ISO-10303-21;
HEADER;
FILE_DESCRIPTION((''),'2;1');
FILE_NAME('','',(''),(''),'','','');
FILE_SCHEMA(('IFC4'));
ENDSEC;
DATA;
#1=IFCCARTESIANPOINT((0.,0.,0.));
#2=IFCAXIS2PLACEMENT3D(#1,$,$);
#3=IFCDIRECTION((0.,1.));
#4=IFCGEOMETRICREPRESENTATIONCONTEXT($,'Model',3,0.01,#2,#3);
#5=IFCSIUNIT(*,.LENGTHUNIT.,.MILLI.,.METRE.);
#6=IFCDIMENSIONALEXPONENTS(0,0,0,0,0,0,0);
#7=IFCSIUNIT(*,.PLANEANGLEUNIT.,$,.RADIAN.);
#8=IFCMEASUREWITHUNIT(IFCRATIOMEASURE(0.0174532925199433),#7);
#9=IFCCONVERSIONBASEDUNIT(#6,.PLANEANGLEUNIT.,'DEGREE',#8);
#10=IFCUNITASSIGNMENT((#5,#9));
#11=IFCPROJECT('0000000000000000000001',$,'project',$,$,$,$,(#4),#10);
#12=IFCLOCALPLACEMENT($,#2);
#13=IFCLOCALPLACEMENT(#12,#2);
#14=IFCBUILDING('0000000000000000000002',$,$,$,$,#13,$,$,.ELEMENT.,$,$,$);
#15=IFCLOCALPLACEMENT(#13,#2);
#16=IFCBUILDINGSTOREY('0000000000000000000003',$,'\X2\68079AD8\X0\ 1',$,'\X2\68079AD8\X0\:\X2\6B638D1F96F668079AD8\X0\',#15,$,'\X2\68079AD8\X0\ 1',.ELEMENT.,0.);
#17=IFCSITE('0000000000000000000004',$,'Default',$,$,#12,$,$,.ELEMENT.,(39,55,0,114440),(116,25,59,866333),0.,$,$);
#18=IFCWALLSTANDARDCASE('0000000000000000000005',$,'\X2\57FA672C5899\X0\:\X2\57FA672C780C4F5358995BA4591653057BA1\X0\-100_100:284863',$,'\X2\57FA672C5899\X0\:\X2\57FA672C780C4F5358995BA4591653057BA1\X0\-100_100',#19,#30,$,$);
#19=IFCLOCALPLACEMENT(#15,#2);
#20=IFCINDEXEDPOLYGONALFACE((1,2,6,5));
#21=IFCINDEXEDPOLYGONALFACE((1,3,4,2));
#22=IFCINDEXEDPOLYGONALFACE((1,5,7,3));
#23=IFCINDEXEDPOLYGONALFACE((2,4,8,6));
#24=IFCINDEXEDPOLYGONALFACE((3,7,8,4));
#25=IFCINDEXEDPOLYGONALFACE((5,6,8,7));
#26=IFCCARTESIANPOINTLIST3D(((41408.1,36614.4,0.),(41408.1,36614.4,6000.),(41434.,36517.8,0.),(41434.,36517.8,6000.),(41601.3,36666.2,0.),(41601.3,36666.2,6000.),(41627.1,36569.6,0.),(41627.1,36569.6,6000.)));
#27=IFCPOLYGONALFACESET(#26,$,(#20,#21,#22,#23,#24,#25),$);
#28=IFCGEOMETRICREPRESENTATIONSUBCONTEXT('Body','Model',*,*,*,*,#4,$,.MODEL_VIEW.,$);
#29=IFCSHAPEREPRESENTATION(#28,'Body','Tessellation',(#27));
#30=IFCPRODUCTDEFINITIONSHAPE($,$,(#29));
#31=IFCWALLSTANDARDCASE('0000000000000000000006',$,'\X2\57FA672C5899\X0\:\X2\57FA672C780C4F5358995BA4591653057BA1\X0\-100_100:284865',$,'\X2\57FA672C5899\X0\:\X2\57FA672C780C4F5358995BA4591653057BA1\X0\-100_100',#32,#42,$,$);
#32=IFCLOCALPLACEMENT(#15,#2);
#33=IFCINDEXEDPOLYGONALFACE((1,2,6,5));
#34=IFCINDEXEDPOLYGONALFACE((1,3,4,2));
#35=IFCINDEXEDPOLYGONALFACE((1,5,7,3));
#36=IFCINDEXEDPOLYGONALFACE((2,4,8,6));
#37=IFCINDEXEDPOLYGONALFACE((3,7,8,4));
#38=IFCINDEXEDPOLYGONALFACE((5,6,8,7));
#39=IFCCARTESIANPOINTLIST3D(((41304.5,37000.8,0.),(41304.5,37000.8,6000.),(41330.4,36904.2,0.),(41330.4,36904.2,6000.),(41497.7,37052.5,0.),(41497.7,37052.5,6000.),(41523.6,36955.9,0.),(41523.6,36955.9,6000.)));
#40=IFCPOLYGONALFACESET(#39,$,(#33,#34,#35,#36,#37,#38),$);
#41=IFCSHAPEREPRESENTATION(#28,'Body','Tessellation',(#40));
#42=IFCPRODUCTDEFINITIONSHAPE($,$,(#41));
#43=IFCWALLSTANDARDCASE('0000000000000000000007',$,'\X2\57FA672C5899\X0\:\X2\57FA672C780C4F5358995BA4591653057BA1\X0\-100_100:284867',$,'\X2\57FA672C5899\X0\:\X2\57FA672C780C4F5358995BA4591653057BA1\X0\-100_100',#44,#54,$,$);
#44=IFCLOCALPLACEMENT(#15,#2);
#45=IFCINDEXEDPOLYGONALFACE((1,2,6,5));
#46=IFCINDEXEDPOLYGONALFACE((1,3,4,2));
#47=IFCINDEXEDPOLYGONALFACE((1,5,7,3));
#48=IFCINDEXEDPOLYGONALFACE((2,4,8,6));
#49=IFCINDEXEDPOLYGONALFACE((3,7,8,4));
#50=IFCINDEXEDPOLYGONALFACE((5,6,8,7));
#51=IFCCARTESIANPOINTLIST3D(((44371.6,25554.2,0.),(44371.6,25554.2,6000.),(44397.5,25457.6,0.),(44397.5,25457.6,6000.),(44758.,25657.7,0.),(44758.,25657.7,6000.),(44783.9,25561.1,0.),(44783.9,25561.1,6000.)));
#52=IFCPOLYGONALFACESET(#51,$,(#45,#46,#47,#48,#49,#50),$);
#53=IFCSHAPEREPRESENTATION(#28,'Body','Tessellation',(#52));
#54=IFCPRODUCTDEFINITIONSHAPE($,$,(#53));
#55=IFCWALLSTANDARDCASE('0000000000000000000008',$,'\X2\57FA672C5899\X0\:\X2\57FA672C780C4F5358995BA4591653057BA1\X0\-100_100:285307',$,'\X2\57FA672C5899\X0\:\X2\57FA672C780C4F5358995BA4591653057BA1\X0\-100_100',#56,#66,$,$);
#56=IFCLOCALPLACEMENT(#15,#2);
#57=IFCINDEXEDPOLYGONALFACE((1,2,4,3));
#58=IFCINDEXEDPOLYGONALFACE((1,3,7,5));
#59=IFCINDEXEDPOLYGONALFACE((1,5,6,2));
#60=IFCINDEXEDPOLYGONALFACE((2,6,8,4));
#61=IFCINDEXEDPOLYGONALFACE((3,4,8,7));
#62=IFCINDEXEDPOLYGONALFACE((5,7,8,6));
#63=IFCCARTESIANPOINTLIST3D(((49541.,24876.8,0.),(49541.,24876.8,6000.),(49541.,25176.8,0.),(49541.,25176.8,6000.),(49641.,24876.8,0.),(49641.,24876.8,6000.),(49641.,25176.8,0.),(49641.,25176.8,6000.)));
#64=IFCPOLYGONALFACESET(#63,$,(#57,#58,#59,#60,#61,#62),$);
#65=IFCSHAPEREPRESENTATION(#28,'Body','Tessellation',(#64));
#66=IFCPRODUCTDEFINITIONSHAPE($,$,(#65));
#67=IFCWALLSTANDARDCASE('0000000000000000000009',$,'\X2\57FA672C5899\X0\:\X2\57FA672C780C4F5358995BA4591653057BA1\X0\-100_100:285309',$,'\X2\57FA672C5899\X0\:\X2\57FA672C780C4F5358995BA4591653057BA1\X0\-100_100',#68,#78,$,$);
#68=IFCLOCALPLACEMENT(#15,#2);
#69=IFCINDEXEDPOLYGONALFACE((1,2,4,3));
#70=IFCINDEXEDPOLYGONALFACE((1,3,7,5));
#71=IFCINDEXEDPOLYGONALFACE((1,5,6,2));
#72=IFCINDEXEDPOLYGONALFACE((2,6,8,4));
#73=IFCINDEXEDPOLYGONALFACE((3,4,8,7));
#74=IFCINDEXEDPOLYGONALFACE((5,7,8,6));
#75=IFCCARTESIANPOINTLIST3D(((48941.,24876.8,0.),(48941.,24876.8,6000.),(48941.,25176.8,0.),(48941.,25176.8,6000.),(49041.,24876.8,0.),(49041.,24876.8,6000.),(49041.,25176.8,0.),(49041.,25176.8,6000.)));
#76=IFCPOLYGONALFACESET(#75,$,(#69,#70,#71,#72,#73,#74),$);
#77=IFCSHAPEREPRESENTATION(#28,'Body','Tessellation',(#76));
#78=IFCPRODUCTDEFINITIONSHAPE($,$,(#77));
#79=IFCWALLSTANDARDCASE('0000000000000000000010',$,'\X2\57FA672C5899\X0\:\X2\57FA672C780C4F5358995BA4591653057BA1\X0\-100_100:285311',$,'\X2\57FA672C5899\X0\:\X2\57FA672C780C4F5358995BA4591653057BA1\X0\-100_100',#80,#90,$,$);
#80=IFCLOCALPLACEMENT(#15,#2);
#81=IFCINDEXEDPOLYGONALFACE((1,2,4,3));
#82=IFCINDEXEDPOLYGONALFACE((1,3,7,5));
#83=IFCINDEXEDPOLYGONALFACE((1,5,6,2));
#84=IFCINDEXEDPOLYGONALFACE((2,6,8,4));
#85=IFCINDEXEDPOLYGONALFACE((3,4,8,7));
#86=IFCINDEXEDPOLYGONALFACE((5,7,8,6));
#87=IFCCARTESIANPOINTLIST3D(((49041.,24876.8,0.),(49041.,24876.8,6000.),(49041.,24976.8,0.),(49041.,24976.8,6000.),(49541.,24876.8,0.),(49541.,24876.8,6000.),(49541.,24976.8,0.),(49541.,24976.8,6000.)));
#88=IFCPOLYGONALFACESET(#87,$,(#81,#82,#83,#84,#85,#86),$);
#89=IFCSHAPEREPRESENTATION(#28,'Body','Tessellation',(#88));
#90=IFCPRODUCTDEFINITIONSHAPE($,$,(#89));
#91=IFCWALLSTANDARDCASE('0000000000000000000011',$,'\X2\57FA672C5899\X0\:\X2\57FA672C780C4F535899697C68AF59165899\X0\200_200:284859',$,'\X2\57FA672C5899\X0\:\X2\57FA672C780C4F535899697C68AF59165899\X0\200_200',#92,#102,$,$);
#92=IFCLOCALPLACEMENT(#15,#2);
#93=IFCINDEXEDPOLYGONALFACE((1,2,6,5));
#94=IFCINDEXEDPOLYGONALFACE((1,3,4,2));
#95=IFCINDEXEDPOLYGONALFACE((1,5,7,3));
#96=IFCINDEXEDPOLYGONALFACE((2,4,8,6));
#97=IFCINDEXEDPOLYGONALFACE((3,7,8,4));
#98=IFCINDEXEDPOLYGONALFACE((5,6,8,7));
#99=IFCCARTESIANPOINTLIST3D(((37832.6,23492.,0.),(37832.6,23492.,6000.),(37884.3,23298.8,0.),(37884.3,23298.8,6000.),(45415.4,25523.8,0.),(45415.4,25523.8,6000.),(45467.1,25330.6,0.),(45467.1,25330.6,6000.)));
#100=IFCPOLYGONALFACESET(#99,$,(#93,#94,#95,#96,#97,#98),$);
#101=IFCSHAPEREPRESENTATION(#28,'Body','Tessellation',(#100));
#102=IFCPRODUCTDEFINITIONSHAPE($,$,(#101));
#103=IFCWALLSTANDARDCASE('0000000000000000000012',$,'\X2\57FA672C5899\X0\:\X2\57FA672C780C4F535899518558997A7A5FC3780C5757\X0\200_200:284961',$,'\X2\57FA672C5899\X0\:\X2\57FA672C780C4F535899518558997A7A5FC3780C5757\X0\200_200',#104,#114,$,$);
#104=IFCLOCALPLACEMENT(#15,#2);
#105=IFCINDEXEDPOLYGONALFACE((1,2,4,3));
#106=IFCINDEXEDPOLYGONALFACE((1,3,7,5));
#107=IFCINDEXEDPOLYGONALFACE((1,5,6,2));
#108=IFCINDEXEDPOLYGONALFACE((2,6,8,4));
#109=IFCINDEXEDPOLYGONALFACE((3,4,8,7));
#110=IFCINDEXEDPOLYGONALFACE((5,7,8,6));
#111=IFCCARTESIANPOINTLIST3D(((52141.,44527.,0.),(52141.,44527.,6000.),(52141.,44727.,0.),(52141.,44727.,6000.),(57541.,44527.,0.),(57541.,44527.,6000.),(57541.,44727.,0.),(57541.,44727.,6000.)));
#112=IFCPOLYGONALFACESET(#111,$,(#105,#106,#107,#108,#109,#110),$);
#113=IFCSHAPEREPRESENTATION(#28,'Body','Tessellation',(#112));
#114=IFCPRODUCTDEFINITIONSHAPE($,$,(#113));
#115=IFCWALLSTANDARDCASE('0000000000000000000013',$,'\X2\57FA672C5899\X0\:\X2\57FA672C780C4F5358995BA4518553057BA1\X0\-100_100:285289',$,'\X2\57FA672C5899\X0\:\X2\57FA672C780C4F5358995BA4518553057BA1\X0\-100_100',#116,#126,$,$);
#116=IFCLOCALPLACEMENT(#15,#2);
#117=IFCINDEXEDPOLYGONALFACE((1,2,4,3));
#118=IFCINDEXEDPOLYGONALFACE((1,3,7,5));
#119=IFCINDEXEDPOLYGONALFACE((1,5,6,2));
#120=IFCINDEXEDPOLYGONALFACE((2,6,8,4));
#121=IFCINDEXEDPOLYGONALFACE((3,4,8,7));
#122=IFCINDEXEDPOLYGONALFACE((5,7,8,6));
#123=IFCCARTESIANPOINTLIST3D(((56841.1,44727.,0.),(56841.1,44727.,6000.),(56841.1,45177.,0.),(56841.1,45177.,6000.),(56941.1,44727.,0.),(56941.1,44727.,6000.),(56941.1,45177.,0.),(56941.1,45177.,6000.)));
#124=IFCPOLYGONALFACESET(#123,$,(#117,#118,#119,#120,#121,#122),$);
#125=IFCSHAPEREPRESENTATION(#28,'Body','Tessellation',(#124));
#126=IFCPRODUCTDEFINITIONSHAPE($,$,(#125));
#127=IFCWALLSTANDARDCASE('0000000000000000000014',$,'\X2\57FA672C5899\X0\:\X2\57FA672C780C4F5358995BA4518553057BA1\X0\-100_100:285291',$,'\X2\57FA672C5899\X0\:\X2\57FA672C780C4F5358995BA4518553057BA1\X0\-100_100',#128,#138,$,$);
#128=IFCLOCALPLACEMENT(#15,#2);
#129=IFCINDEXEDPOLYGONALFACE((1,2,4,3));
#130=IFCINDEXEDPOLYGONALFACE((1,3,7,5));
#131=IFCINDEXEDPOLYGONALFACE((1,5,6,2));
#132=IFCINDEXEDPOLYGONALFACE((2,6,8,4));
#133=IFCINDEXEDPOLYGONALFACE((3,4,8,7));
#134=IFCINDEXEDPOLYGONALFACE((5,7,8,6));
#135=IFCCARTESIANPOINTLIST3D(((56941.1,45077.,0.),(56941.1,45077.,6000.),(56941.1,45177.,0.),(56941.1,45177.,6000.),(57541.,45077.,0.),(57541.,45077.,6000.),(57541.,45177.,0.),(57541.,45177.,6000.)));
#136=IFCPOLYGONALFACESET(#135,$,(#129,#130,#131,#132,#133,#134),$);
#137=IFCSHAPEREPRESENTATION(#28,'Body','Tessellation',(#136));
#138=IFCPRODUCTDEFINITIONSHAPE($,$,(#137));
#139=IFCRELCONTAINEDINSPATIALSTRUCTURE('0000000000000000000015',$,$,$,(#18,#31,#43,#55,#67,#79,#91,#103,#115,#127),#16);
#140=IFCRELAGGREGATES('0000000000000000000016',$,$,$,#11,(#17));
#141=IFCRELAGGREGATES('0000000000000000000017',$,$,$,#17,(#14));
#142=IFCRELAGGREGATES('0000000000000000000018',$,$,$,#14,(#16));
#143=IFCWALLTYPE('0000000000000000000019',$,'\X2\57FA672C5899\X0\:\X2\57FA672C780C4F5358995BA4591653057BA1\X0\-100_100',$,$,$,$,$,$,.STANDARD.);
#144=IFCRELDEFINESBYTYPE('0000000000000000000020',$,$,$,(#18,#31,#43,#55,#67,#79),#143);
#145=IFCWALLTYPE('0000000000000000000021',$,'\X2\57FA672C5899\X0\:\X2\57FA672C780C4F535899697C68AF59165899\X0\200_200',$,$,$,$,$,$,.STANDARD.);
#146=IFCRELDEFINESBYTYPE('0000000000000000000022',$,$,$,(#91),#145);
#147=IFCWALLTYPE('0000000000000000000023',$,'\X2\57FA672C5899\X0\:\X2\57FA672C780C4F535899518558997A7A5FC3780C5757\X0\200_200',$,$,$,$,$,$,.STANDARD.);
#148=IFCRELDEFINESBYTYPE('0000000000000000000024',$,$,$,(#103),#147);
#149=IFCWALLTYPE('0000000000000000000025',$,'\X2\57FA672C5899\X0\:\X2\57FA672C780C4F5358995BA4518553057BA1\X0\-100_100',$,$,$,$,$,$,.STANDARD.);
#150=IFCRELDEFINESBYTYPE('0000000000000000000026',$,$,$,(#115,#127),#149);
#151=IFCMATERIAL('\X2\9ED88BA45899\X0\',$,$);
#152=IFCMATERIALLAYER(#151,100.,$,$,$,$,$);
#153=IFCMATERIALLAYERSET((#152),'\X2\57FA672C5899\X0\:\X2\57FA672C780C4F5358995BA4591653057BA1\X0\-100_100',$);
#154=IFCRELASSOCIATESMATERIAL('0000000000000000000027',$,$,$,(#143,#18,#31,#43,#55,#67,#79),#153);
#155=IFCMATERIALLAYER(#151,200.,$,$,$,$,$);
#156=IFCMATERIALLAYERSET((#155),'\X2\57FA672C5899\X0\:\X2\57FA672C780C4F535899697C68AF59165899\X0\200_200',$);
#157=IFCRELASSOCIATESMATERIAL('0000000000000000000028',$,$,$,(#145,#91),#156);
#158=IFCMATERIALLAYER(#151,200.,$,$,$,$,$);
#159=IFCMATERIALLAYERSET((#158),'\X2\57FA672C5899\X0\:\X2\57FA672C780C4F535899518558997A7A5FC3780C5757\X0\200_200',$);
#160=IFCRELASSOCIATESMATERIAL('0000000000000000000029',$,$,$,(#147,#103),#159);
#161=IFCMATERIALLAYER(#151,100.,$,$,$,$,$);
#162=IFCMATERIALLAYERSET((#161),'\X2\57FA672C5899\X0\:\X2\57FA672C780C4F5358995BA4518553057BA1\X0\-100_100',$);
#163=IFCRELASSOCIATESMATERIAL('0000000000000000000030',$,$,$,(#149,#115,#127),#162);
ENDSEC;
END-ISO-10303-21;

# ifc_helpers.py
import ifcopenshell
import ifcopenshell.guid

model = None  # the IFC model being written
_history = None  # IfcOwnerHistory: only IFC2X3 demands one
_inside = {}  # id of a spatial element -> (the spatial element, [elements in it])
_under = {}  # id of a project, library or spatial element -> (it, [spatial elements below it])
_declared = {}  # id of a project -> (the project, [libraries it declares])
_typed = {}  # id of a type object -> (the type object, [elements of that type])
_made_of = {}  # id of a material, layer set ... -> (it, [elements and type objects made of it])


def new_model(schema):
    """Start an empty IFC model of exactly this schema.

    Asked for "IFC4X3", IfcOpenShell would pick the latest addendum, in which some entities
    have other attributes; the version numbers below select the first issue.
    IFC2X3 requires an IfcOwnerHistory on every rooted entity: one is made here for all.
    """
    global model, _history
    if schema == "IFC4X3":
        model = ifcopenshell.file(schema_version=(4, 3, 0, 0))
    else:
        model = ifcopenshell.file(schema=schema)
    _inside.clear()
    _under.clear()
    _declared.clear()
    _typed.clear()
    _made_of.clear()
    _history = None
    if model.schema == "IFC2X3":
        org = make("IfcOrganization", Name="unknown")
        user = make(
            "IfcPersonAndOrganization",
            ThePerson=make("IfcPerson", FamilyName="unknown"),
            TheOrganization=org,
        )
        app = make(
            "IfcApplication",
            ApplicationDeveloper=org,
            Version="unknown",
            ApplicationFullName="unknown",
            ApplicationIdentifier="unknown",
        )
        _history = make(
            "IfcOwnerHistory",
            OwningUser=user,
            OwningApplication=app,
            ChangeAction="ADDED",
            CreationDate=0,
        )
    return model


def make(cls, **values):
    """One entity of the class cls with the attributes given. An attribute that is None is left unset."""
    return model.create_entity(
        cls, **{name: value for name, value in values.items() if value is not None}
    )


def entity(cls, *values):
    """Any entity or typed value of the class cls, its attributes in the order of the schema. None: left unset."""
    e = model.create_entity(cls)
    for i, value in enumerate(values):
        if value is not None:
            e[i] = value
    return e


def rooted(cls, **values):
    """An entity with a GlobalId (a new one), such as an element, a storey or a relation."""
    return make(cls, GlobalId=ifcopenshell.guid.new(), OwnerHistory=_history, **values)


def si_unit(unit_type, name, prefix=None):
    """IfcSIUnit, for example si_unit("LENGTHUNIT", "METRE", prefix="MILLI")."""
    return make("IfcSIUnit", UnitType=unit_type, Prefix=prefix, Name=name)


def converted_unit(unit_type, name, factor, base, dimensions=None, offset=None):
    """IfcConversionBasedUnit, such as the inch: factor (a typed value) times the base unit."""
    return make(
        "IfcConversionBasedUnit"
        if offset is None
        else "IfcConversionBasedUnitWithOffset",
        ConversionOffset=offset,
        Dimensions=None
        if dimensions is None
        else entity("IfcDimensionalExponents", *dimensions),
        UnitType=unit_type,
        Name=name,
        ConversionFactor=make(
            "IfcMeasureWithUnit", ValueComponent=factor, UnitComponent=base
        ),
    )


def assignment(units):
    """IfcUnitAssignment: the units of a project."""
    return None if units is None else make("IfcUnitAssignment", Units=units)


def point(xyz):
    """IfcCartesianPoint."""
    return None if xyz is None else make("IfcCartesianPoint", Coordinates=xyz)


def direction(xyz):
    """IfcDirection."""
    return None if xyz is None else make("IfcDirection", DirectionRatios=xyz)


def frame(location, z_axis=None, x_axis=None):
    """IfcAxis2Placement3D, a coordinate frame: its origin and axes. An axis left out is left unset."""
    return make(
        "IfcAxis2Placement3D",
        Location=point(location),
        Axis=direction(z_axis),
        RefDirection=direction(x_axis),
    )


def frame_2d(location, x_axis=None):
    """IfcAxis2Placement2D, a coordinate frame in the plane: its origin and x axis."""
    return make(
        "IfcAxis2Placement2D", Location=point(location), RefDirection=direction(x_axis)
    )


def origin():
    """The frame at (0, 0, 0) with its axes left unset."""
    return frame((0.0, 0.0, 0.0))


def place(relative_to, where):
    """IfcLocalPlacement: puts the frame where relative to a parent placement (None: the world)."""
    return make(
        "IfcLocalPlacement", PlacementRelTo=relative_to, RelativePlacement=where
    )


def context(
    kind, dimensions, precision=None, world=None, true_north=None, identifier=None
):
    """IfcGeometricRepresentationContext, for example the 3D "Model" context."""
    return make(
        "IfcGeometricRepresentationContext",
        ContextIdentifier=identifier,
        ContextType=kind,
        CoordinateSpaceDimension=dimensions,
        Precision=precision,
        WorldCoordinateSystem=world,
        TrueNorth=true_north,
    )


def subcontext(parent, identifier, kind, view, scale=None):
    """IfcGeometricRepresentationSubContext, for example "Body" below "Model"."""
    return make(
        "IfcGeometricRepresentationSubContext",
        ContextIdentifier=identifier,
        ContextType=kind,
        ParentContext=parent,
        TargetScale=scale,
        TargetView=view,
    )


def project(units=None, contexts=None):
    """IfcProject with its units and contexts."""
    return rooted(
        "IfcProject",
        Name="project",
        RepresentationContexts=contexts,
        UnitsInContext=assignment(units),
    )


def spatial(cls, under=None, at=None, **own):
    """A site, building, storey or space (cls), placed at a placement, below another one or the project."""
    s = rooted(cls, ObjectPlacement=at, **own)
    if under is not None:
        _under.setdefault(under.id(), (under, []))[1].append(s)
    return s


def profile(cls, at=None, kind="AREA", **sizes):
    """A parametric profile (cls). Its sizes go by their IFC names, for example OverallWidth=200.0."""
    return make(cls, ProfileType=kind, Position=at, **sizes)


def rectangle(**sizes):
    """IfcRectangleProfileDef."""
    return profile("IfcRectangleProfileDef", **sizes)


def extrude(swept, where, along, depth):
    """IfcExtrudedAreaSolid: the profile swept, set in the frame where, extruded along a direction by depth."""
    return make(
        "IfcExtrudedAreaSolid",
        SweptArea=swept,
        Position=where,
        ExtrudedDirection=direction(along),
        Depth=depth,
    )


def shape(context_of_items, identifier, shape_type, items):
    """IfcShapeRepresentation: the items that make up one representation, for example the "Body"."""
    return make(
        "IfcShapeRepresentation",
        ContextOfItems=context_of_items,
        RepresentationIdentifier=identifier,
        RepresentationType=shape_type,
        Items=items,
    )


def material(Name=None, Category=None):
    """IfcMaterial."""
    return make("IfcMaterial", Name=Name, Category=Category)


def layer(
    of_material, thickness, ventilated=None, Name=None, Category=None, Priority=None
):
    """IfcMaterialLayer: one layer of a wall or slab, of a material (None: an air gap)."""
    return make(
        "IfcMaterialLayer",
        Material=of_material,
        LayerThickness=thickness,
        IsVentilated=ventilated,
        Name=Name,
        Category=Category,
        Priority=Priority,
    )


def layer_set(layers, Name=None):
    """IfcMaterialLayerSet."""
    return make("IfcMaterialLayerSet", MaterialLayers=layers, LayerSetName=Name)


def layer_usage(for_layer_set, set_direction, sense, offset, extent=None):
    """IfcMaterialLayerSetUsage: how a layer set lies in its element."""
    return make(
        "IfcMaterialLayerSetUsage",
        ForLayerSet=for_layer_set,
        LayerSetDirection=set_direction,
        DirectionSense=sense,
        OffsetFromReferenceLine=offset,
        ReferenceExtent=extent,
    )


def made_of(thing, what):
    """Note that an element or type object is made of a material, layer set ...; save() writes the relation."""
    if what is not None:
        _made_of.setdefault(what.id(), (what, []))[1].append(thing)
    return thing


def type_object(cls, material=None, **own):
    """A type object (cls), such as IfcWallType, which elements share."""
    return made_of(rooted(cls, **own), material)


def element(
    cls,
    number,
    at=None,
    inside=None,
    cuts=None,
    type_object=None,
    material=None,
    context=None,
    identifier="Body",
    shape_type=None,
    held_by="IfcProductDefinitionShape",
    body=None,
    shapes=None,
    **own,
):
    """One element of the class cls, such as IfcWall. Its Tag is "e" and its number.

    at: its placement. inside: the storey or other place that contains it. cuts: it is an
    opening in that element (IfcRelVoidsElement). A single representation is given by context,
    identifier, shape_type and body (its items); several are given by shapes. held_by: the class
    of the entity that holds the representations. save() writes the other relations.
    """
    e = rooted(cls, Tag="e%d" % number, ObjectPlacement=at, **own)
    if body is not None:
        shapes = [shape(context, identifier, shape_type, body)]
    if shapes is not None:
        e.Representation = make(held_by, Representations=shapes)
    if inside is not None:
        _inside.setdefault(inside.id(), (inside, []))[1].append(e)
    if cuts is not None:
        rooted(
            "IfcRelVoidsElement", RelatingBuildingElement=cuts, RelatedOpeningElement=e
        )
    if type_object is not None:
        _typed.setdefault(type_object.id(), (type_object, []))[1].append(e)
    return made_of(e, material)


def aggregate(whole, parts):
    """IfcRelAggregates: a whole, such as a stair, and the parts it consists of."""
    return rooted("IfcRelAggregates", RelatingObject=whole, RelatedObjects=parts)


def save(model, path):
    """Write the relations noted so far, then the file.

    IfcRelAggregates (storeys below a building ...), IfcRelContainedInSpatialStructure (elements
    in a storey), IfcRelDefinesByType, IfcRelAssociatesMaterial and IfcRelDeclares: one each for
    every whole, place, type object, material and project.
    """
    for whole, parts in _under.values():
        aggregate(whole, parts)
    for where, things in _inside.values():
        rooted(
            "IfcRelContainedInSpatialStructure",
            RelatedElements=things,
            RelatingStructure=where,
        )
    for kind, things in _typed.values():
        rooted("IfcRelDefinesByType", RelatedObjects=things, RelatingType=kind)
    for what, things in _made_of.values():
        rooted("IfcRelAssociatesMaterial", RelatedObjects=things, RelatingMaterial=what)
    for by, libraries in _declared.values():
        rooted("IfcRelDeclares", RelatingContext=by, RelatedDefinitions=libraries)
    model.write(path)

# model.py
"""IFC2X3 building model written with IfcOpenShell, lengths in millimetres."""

from ifc_helpers import new_model, entity, si_unit, converted_unit, direction, frame, frame_2d, origin, place, context, subcontext, project, spatial, rectangle, extrude, material, layer, layer_set, layer_usage, type_object, element, save


model = new_model("IFC2X3")

# Units and contexts
model_context = context("Model", 3, precision=0.01, world=origin(), true_north=direction((0.0, 1.0)))
body_context = subcontext(model_context, "Body", "Model", "MODEL_VIEW")
ifc_project = project(units=[si_unit("LENGTHUNIT", "METRE", prefix="MILLI"), converted_unit("PLANEANGLEUNIT", "DEGREE", entity("IfcRatioMeasure", 0.0174532925199433), si_unit("PLANEANGLEUNIT", "RADIAN"), dimensions=[0, 0, 0, 0, 0, 0, 0])], contexts=[model_context])

# Site, building, storey
site_placement = place(None, origin())
site = spatial("IfcSite", under=ifc_project, at=site_placement, Name="Default", CompositionType="ELEMENT", RefLatitude=(39, 55, 0, 114440), RefLongitude=(116, 25, 59, 866333), RefElevation=0.0)
building_placement = place(site_placement, origin())
building = spatial("IfcBuilding", under=site, at=building_placement, CompositionType="ELEMENT")
storey_placement = place(building_placement, origin())
storey = spatial("IfcBuildingStorey", under=building, at=storey_placement, Name="标高 1", ObjectType="标高:正负零标高", LongName="标高 1", CompositionType="ELEMENT", Elevation=0.0)

# Walls
ifc_material = material(Name="默认墙")
ifc_layer_1 = layer(ifc_material, 100.0)
ifc_layer_set_1 = layer_set([ifc_layer_1], Name="基本墙:基本砌体墙室外包管-100_100")
wall_type_1 = type_object("IfcWallType", Name="基本墙:基本砌体墙室外包管-100_100", PredefinedType="STANDARD", material=ifc_layer_set_1)
ifc_layer_usage_1 = layer_usage(ifc_layer_set_1, "AXIS2", "NEGATIVE", 50.0)
wall_1_placement = place(building_placement, frame((41421.0, 36566.1, 0.0), z_axis=(0.0, 0.0, 1.0), x_axis=(0.965926, 0.258819, 0.0)))
element("IfcWallStandardCase", 1, at=wall_1_placement, inside=storey, type_object=wall_type_1, material=ifc_layer_usage_1, Name="基本墙:基本砌体墙室外包管-100_100:284863", ObjectType="基本墙:基本砌体墙室外包管-100_100", context=body_context, shape_type="SweptSolid", body=[
    extrude(rectangle(XDim=200.0, YDim=100.0, at=frame_2d((100.0, 0.0), x_axis=(-1.0, 0.0))), origin(), (0.0, 0.0, 1.0), 6000.0),
])
ifc_layer_usage_2 = layer_usage(ifc_layer_set_1, "AXIS2", "NEGATIVE", 50.0)
wall_2_placement = place(building_placement, frame((41317.5, 36952.5, 0.0), z_axis=(0.0, 0.0, 1.0), x_axis=(0.965926, 0.258819, 0.0)))
element("IfcWallStandardCase", 2, at=wall_2_placement, inside=storey, type_object=wall_type_1, material=ifc_layer_usage_2, Name="基本墙:基本砌体墙室外包管-100_100:284865", ObjectType="基本墙:基本砌体墙室外包管-100_100", context=body_context, shape_type="SweptSolid", body=[
    extrude(rectangle(XDim=200.0, YDim=100.0, at=frame_2d((100.0, 0.0), x_axis=(-1.0, 0.0))), origin(), (0.0, 0.0, 1.0), 6000.0),
])
ifc_layer_usage_3 = layer_usage(ifc_layer_set_1, "AXIS2", "NEGATIVE", 50.0)
wall_3_placement = place(building_placement, frame((44384.6, 25505.9, 0.0), z_axis=(0.0, 0.0, 1.0), x_axis=(0.965926, 0.258819, 0.0)))
element("IfcWallStandardCase", 3, at=wall_3_placement, inside=storey, type_object=wall_type_1, material=ifc_layer_usage_3, Name="基本墙:基本砌体墙室外包管-100_100:284867", ObjectType="基本墙:基本砌体墙室外包管-100_100", context=body_context, shape_type="SweptSolid", body=[
    extrude(rectangle(XDim=400.0, YDim=100.0, at=frame_2d((200.0, 0.0), x_axis=(-1.0, 0.0))), origin(), (0.0, 0.0, 1.0), 6000.0),
])
ifc_layer_usage_4 = layer_usage(ifc_layer_set_1, "AXIS2", "NEGATIVE", 50.0)
wall_4_placement = place(building_placement, frame((49591.0, 24876.8, 0.0), z_axis=(0.0, 0.0, 1.0), x_axis=(0.0, 1.0, 0.0)))
element("IfcWallStandardCase", 4, at=wall_4_placement, inside=storey, type_object=wall_type_1, material=ifc_layer_usage_4, Name="基本墙:基本砌体墙室外包管-100_100:285307", ObjectType="基本墙:基本砌体墙室外包管-100_100", context=body_context, shape_type="SweptSolid", body=[
    extrude(rectangle(XDim=300.0, YDim=100.0, at=frame_2d((150.0, 0.0), x_axis=(-1.0, 0.0))), origin(), (0.0, 0.0, 1.0), 6000.0),
])
ifc_layer_usage_5 = layer_usage(ifc_layer_set_1, "AXIS2", "NEGATIVE", 50.0)
wall_5_placement = place(building_placement, frame((48991.0, 24876.8, 0.0), z_axis=(0.0, 0.0, 1.0), x_axis=(0.0, 1.0, 0.0)))
element("IfcWallStandardCase", 5, at=wall_5_placement, inside=storey, type_object=wall_type_1, material=ifc_layer_usage_5, Name="基本墙:基本砌体墙室外包管-100_100:285309", ObjectType="基本墙:基本砌体墙室外包管-100_100", context=body_context, shape_type="SweptSolid", body=[
    extrude(rectangle(XDim=300.0, YDim=100.0, at=frame_2d((150.0, 0.0), x_axis=(-1.0, 0.0))), origin(), (0.0, 0.0, 1.0), 6000.0),
])
ifc_layer_usage_6 = layer_usage(ifc_layer_set_1, "AXIS2", "NEGATIVE", 50.0)
wall_6_placement = place(building_placement, frame((49041.0, 24926.8, 0.0)))
element("IfcWallStandardCase", 6, at=wall_6_placement, inside=storey, type_object=wall_type_1, material=ifc_layer_usage_6, Name="基本墙:基本砌体墙室外包管-100_100:285311", ObjectType="基本墙:基本砌体墙室外包管-100_100", context=body_context, shape_type="SweptSolid", body=[
    extrude(rectangle(XDim=500.0, YDim=100.0, at=frame_2d((250.0, 0.0), x_axis=(-1.0, 0.0))), origin(), (0.0, 0.0, 1.0), 6000.0),
])
ifc_layer_2 = layer(ifc_material, 200.0)
ifc_layer_set_2 = layer_set([ifc_layer_2], Name="基本墙:基本砌体墙楼梯外墙200_200")
ifc_layer_usage_7 = layer_usage(ifc_layer_set_2, "AXIS2", "NEGATIVE", 100.0)
wall_type_2 = type_object("IfcWallType", Name="基本墙:基本砌体墙楼梯外墙200_200", PredefinedType="STANDARD", material=ifc_layer_set_2)
wall_7_placement = place(building_placement, frame((45441.2, 25427.2, 0.0), z_axis=(0.0, 0.0, 1.0), x_axis=(-0.965926, -0.258819, 0.0)))
element("IfcWallStandardCase", 7, at=wall_7_placement, inside=storey, type_object=wall_type_2, material=ifc_layer_usage_7, Name="基本墙:基本砌体墙楼梯外墙200_200:284859", ObjectType="基本墙:基本砌体墙楼梯外墙200_200", context=body_context, shape_type="SweptSolid", body=[
    extrude(rectangle(XDim=7850.3, YDim=200.0, at=frame_2d((3925.1, 0.0), x_axis=(-1.0, 0.0))), origin(), (0.0, 0.0, 1.0), 6000.0),
])
ifc_layer_3 = layer(ifc_material, 200.0)
ifc_layer_set_3 = layer_set([ifc_layer_3], Name="基本墙:基本砌体墙内墙空心砌块200_200")
ifc_layer_usage_8 = layer_usage(ifc_layer_set_3, "AXIS2", "NEGATIVE", 100.0)
wall_type_3 = type_object("IfcWallType", Name="基本墙:基本砌体墙内墙空心砌块200_200", PredefinedType="STANDARD", material=ifc_layer_set_3)
wall_8_placement = place(building_placement, frame((52141.0, 44627.0, 0.0)))
element("IfcWallStandardCase", 8, at=wall_8_placement, inside=storey, type_object=wall_type_3, material=ifc_layer_usage_8, Name="基本墙:基本砌体墙内墙空心砌块200_200:284961", ObjectType="基本墙:基本砌体墙内墙空心砌块200_200", context=body_context, shape_type="SweptSolid", body=[
    extrude(rectangle(XDim=5400.0, YDim=200.0, at=frame_2d((2700.0, 0.0), x_axis=(-1.0, 0.0))), origin(), (0.0, 0.0, 1.0), 6000.0),
])
ifc_layer_4 = layer(ifc_material, 100.0)
ifc_layer_set_4 = layer_set([ifc_layer_4], Name="基本墙:基本砌体墙室内包管-100_100")
ifc_layer_usage_9 = layer_usage(ifc_layer_set_4, "AXIS2", "NEGATIVE", 50.0)
wall_type_4 = type_object("IfcWallType", Name="基本墙:基本砌体墙室内包管-100_100", PredefinedType="STANDARD", material=ifc_layer_set_4)
wall_9_placement = place(building_placement, frame((56891.1, 45177.0, 0.0), z_axis=(0.0, 0.0, 1.0), x_axis=(0.0, -1.0, 0.0)))
element("IfcWallStandardCase", 9, at=wall_9_placement, inside=storey, type_object=wall_type_4, material=ifc_layer_usage_9, Name="基本墙:基本砌体墙室内包管-100_100:285289", ObjectType="基本墙:基本砌体墙室内包管-100_100", context=body_context, shape_type="SweptSolid", body=[
    extrude(rectangle(XDim=450.0, YDim=100.0, at=frame_2d((225.0, 0.0), x_axis=(-1.0, 0.0))), origin(), (0.0, 0.0, 1.0), 6000.0),
])
ifc_layer_usage_10 = layer_usage(ifc_layer_set_4, "AXIS2", "NEGATIVE", 50.0)
wall_10_placement = place(building_placement, frame((57541.0, 45127.0, 0.0), z_axis=(0.0, 0.0, 1.0), x_axis=(-1.0, 0.0, 0.0)))
element("IfcWallStandardCase", 10, at=wall_10_placement, inside=storey, type_object=wall_type_4, material=ifc_layer_usage_10, Name="基本墙:基本砌体墙室内包管-100_100:285291", ObjectType="基本墙:基本砌体墙室内包管-100_100", context=body_context, shape_type="SweptSolid", body=[
    extrude(rectangle(XDim=599.9, YDim=100.0, at=frame_2d((299.9, 0.0), x_axis=(-1.0, 0.0))), origin(), (0.0, 0.0, 1.0), 6000.0),
])

save(model, "model.ifc")
